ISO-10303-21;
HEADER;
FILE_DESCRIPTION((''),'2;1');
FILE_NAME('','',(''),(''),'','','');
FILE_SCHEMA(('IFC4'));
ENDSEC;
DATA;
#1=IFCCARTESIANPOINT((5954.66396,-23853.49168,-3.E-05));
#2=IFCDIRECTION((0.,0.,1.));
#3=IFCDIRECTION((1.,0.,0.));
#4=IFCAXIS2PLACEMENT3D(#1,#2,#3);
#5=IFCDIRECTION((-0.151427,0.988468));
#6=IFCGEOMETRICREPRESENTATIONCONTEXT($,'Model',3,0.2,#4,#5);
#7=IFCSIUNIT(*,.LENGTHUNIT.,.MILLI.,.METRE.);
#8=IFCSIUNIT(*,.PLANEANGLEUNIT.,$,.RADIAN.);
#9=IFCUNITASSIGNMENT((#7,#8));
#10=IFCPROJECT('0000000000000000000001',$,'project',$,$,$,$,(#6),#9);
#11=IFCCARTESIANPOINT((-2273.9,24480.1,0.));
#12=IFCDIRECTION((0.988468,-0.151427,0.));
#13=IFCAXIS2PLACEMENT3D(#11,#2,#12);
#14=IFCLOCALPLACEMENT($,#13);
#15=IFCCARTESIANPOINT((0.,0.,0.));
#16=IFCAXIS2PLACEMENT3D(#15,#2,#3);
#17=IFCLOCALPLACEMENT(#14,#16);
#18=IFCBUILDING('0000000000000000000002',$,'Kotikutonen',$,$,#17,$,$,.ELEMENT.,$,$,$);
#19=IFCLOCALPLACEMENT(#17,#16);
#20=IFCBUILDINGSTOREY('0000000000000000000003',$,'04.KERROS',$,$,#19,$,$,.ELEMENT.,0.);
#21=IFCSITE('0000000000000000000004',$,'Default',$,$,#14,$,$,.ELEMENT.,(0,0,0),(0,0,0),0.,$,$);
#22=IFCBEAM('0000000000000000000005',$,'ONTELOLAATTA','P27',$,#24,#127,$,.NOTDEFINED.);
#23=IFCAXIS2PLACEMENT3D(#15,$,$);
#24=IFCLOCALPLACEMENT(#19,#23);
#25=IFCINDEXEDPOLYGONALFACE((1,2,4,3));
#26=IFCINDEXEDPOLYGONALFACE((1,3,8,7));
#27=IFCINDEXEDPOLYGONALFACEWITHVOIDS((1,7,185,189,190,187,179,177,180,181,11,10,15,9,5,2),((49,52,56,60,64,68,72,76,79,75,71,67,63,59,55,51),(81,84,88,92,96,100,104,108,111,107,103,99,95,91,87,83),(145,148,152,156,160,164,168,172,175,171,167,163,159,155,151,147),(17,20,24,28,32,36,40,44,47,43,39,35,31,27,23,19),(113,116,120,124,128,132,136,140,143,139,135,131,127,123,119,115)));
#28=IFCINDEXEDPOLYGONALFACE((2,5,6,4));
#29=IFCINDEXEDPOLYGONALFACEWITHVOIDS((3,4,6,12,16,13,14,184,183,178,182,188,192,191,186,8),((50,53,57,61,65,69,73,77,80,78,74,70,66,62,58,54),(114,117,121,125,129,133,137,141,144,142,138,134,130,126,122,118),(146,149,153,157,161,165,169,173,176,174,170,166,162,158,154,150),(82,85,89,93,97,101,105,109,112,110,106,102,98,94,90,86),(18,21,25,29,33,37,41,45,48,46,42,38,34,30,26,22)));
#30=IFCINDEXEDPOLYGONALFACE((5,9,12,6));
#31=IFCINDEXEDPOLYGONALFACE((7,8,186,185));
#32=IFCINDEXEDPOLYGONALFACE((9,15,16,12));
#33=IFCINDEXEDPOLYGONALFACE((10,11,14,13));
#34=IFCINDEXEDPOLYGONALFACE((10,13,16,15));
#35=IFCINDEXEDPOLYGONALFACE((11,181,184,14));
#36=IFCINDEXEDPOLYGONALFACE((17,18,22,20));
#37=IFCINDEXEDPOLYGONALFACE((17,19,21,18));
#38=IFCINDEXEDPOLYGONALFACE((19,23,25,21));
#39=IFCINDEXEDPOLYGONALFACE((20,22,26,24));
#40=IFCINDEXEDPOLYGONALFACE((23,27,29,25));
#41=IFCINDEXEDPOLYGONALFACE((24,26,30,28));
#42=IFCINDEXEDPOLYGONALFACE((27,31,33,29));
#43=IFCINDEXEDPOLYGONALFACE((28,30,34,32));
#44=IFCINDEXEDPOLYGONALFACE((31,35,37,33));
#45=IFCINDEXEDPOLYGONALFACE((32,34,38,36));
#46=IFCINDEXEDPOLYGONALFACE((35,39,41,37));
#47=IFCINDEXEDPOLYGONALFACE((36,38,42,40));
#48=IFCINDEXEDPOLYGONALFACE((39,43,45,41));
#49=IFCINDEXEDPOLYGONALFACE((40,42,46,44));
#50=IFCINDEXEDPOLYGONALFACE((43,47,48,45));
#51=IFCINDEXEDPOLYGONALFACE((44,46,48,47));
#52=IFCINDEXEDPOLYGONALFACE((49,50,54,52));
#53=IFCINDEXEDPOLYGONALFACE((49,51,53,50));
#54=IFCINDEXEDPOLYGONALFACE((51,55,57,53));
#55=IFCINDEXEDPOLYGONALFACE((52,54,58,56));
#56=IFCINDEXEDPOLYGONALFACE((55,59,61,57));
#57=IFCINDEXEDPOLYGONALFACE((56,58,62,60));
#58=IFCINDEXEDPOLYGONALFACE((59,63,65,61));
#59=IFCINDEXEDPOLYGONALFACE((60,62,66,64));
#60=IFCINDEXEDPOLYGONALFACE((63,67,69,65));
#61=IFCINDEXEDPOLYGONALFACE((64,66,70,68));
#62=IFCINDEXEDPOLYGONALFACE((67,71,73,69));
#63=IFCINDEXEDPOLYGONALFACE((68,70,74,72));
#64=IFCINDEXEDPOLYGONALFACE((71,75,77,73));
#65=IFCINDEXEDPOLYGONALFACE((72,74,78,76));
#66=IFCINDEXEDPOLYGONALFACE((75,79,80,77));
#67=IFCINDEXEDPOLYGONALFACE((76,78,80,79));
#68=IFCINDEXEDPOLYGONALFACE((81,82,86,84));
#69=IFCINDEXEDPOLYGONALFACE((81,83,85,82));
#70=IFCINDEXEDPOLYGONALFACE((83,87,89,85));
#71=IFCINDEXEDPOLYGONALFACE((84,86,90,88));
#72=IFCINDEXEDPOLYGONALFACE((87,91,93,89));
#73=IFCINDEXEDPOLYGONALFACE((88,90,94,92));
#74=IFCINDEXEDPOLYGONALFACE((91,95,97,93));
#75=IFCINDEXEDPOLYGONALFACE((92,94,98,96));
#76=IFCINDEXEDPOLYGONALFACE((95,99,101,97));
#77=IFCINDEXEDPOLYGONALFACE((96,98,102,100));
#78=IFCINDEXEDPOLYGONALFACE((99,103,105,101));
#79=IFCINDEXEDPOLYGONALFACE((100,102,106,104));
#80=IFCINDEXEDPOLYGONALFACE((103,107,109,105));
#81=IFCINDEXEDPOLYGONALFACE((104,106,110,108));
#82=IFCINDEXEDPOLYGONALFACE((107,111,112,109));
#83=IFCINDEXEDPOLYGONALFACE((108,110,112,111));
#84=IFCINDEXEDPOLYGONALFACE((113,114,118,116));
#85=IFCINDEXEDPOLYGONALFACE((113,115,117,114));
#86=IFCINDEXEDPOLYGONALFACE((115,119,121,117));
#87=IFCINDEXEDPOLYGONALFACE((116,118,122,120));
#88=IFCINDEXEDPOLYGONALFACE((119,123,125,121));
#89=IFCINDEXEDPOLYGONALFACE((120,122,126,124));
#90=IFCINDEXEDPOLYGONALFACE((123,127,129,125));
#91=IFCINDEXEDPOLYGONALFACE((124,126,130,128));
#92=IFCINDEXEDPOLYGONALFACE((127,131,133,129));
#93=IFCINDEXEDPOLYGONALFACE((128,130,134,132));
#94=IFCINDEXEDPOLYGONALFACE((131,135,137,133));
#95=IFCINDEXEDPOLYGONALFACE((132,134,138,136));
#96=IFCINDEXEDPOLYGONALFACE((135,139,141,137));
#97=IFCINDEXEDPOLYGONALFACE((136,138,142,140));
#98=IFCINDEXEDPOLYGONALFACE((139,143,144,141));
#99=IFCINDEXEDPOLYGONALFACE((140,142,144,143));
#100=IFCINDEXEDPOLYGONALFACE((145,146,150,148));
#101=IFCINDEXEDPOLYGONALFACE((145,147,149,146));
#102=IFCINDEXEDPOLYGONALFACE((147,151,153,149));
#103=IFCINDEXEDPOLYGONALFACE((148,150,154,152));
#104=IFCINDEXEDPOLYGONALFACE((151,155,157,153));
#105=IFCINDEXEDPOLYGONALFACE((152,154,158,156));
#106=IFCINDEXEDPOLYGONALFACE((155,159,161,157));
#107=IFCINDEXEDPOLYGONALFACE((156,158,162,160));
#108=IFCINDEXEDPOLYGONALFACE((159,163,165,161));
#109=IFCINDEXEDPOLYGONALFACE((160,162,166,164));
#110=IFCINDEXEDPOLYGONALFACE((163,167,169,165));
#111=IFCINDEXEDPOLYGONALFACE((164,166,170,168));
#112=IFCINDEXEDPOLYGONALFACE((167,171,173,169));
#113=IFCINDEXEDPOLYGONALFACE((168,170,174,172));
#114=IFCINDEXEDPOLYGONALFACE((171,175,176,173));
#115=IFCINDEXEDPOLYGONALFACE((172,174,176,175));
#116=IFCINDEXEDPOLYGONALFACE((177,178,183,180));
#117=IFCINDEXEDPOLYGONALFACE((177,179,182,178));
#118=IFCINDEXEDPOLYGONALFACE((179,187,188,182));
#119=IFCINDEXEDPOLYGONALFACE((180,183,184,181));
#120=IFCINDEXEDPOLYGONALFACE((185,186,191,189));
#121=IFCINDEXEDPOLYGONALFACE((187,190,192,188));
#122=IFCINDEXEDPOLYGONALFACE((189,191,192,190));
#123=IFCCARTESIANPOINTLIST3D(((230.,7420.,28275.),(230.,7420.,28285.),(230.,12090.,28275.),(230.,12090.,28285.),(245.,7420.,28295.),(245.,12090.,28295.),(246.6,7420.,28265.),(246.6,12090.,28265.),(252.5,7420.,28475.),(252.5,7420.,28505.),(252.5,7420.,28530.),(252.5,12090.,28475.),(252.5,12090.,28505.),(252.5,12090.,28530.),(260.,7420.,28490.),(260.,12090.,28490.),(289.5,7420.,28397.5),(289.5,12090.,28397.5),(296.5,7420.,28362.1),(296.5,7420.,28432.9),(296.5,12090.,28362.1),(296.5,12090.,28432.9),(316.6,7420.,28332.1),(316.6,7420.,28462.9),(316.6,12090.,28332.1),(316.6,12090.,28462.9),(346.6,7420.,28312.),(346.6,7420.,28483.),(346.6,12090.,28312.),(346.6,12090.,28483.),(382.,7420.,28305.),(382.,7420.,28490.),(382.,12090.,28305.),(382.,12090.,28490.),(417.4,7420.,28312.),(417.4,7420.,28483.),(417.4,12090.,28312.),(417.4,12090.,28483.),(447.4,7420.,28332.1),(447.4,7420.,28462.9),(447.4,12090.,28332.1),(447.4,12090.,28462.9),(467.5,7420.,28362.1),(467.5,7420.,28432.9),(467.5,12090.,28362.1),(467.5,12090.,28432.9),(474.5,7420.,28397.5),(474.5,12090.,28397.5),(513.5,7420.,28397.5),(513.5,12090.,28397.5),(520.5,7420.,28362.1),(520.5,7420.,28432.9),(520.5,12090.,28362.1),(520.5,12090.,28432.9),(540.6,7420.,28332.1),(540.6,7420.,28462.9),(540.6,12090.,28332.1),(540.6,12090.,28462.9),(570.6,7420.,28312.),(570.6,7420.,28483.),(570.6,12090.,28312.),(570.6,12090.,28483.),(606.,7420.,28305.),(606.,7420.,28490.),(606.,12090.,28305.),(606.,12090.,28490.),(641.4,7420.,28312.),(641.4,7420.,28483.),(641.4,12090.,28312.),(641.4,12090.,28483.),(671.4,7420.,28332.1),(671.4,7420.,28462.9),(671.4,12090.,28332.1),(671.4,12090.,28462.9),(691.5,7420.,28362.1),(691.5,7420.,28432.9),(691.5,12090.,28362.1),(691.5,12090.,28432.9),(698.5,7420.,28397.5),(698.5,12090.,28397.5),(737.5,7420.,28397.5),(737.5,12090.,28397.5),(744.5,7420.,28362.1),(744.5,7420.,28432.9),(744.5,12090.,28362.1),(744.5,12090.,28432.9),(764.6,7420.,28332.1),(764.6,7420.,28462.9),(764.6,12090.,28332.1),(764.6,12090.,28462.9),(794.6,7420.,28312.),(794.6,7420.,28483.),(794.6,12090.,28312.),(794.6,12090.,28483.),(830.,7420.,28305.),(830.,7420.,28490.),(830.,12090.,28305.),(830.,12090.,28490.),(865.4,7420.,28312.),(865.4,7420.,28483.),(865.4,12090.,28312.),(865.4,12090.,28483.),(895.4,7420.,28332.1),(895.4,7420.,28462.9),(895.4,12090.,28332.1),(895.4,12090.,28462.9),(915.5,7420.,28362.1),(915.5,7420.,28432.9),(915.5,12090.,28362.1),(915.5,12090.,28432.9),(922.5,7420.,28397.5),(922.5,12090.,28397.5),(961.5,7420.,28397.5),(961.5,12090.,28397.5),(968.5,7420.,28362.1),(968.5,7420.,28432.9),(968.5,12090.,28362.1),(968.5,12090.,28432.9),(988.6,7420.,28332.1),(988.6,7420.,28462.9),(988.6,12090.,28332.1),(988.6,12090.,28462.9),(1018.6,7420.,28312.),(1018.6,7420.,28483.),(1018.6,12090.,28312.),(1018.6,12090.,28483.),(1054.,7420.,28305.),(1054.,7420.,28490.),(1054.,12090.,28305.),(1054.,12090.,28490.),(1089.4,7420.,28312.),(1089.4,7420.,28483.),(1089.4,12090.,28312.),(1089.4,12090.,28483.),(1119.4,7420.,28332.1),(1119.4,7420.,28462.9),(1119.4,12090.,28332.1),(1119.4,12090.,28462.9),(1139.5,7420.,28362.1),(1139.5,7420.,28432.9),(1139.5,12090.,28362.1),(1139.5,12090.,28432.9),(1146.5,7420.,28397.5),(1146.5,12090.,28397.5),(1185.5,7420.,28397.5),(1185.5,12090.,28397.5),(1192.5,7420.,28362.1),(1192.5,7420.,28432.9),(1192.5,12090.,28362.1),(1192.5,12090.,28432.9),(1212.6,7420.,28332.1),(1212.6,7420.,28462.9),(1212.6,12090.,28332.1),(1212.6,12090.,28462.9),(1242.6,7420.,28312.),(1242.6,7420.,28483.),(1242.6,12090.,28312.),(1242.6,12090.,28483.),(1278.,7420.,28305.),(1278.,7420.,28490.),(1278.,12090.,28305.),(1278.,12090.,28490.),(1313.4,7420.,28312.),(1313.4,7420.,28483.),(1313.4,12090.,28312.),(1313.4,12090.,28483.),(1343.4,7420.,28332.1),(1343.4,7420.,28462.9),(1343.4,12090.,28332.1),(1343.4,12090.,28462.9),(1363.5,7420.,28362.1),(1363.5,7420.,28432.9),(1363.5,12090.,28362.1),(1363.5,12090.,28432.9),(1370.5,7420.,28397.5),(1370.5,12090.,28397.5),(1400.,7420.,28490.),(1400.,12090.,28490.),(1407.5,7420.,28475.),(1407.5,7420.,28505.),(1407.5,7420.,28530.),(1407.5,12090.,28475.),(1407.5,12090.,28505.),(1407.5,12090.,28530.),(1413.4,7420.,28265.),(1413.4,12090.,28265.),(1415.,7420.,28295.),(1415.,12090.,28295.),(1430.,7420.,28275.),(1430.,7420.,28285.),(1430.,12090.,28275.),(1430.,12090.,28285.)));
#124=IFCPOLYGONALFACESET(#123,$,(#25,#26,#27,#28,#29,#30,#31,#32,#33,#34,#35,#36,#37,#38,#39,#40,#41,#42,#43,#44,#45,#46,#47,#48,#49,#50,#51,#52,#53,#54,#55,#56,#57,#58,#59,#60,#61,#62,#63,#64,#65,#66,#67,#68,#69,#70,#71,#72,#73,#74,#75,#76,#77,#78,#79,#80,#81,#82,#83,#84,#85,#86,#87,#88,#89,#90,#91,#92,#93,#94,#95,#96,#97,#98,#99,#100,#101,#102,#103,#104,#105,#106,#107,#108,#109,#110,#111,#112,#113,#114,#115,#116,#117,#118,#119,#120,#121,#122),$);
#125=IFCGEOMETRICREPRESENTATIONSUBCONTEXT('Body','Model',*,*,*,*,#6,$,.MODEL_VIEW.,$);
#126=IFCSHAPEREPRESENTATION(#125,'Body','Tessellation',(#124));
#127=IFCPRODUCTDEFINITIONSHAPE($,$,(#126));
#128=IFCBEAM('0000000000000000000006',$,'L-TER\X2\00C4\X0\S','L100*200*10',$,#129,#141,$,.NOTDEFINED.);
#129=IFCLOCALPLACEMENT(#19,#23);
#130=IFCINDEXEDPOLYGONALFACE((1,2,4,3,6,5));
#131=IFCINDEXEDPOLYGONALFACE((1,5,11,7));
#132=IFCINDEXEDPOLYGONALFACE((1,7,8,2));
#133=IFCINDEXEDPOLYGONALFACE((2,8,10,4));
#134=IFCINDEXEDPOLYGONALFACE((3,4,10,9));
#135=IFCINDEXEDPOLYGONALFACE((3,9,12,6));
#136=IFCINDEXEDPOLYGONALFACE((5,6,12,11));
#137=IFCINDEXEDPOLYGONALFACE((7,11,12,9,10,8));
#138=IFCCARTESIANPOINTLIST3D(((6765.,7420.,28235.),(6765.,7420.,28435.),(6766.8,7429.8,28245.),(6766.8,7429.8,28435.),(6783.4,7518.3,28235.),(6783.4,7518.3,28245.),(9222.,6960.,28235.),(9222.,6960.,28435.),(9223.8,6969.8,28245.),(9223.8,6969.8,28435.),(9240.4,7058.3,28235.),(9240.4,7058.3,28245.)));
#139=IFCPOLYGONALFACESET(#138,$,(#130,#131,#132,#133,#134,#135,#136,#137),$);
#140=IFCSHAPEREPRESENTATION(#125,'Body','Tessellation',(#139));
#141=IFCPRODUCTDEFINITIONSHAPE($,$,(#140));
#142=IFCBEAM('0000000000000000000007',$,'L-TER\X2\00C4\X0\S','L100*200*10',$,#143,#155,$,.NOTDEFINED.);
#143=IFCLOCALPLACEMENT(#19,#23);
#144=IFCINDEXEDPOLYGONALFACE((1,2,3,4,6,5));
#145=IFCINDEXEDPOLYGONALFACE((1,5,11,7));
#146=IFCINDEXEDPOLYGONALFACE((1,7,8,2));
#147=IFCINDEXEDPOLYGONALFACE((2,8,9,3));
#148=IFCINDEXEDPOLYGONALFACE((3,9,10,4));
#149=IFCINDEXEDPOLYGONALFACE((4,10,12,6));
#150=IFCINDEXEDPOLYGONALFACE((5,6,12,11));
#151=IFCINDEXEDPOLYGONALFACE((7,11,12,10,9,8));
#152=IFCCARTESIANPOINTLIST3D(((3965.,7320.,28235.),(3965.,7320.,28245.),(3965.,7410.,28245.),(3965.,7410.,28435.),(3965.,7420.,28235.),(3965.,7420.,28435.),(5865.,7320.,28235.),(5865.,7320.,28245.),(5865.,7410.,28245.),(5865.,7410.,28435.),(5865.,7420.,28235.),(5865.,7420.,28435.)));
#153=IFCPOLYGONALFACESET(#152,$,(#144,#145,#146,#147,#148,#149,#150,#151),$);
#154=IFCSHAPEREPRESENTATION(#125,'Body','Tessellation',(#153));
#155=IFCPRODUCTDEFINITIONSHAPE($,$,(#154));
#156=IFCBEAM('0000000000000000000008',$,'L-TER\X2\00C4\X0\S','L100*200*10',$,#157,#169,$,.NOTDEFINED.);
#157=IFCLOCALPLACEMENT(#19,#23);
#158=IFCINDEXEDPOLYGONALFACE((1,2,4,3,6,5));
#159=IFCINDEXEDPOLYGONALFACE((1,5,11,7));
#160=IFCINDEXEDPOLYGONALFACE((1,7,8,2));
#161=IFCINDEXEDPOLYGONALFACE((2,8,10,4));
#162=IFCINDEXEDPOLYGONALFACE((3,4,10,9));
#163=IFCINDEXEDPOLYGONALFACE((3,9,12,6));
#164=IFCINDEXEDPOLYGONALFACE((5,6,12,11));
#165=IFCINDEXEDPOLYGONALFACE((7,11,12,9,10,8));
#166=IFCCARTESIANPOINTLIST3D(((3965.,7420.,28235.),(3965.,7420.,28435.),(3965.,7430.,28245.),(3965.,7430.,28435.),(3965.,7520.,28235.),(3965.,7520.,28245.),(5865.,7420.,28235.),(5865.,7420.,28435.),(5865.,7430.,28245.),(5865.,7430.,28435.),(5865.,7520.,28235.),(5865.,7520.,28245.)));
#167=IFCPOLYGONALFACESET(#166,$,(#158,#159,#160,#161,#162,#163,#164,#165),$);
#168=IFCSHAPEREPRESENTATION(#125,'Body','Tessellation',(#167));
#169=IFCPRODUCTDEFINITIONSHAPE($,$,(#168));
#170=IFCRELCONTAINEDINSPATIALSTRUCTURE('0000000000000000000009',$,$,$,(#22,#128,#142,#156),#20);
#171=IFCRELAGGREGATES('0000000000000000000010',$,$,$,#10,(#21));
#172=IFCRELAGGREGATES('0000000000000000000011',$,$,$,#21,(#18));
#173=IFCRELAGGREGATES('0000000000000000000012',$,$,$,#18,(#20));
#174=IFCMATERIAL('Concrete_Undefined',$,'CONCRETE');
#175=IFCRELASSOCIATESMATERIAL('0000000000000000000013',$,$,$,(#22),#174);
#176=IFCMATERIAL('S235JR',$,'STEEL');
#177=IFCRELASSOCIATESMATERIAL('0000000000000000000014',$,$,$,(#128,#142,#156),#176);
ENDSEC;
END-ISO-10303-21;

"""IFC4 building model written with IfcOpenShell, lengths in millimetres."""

from ifc_helpers import new_model, si_unit, direction, frame, origin_with_axes, place, context, subcontext, project, spatial, line, indexed_curve, outline, extrude, material, element, save


model = new_model("IFC4")

# Units and contexts
model_context = context("Model", 3, precision=0.2, world=frame((5954.66396, -23853.49168, -3e-05), z_axis=(0.0, 0.0, 1.0), x_axis=(1.0, 0.0, 0.0)), true_north=direction((-0.151427, 0.988468)))
body_context = subcontext(model_context, "Body", "Model", "MODEL_VIEW")
ifc_project = project(units=[si_unit("LENGTHUNIT", "METRE", prefix="MILLI"), si_unit("PLANEANGLEUNIT", "RADIAN")], contexts=[model_context])

# Site, building, storey
site_placement = place(None, frame((-2273.9, 24480.1, 0.0), z_axis=(0.0, 0.0, 1.0), x_axis=(0.988468, -0.151427, 0.0)))
site = spatial("IfcSite", under=ifc_project, at=site_placement, Name="Default", CompositionType="ELEMENT", RefLatitude=(0, 0, 0), RefLongitude=(0, 0, 0), RefElevation=0.0)
building_placement = place(site_placement, origin_with_axes())
building = spatial("IfcBuilding", under=site, at=building_placement, Name="Kotikutonen", CompositionType="ELEMENT")
storey_placement = place(building_placement, origin_with_axes())
storey = spatial("IfcBuildingStorey", under=building, at=storey_placement, Name="04.KERROS", CompositionType="ELEMENT", Elevation=0.0)

# Beams
ifc_material_1 = material(Name="Concrete_Undefined", Category="CONCRETE")
beam_1_placement = place(storey_placement, frame((830.0, 12090.0, 28397.5), z_axis=(-1.0, 0.0, 0.0), x_axis=(0.0, -1.0, 0.0)))
element("IfcBeam", 1, at=beam_1_placement, inside=storey, material=ifc_material_1, Name="ONTELOLAATTA", Description="P27", PredefinedType="NOTDEFINED", context=body_context, shape_type="SolidModel", body=[
    extrude(outline(indexed_curve([(-600.0, -122.5), (-583.4, -132.5), (583.4, -132.5), (600.0, -122.5), (600.0, -112.5), (585.0, -102.5), (577.5, 77.5), (570.0, 92.5), (577.5, 107.5), (577.5, 132.5), (-577.5, 132.5), (-577.5, 107.5), (-570.0, 92.5), (-577.5, 77.5), (-585.0, -102.5), (-600.0, -112.5)], segments=[line(1, 2, 3, 4, 5, 6, 7, 8, 9, 10, 11, 12, 13, 14, 15, 16, 1)]), holes=[indexed_curve([(-448.0, -92.5), (-483.4, -85.5), (-513.4, -65.4), (-533.5, -35.4), (-540.5, 0.0), (-533.5, 35.4), (-513.4, 65.4), (-483.4, 85.5), (-448.0, 92.5), (-412.6, 85.5), (-382.6, 65.4), (-362.5, 35.4), (-355.5, 0.0), (-362.5, -35.4), (-382.6, -65.4), (-412.6, -85.5)], segments=[line(1, 2, 3, 4, 5, 6, 7, 8, 9, 10, 11, 12, 13, 14, 15, 16, 1)]), indexed_curve([(-224.0, -92.5), (-259.4, -85.5), (-289.4, -65.4), (-309.5, -35.4), (-316.5, 0.0), (-309.5, 35.4), (-289.4, 65.4), (-259.4, 85.5), (-224.0, 92.5), (-188.6, 85.5), (-158.6, 65.4), (-138.5, 35.4), (-131.5, 0.0), (-138.5, -35.4), (-158.6, -65.4), (-188.6, -85.5)], segments=[line(1, 2, 3, 4, 5, 6, 7, 8, 9, 10, 11, 12, 13, 14, 15, 16, 1)]), indexed_curve([(0.0, -92.5), (-35.4, -85.5), (-65.4, -65.4), (-85.5, -35.4), (-92.5, 0.0), (-85.5, 35.4), (-65.4, 65.4), (-35.4, 85.5), (0.0, 92.5), (35.4, 85.5), (65.4, 65.4), (85.5, 35.4), (92.5, 0.0), (85.5, -35.4), (65.4, -65.4), (35.4, -85.5)], segments=[line(1, 2, 3, 4, 5, 6, 7, 8, 9, 10, 11, 12, 13, 14, 15, 16, 1)]), indexed_curve([(224.0, -92.5), (188.6, -85.5), (158.6, -65.4), (138.5, -35.4), (131.5, 0.0), (138.5, 35.4), (158.6, 65.4), (188.6, 85.5), (224.0, 92.5), (259.4, 85.5), (289.4, 65.4), (309.5, 35.4), (316.5, 0.0), (309.5, -35.4), (289.4, -65.4), (259.4, -85.5)], segments=[line(1, 2, 3, 4, 5, 6, 7, 8, 9, 10, 11, 12, 13, 14, 15, 16, 1)]), indexed_curve([(448.0, -92.5), (412.6, -85.5), (382.6, -65.4), (362.5, -35.4), (355.5, 0.0), (362.5, 35.4), (382.6, 65.4), (412.6, 85.5), (448.0, 92.5), (483.4, 85.5), (513.4, 65.4), (533.5, 35.4), (540.5, 0.0), (533.5, -35.4), (513.4, -65.4), (483.4, -85.5)], segments=[line(1, 2, 3, 4, 5, 6, 7, 8, 9, 10, 11, 12, 13, 14, 15, 16, 1)])]), frame((0.0, 0.0, 0.0), z_axis=(-1.0, 0.0, 0.0), x_axis=(0.0, 0.0, 1.0)), (0.0, 0.0, -1.0), 4670.0),
])
ifc_material_2 = material(Name="S235JR", Category="STEEL")
beam_2_placement = place(storey_placement, frame((6774.2, 7469.1, 28335.0), z_axis=(0.0, 0.0, 1.0), x_axis=(0.982922, -0.184023, 0.0)))
element("IfcBeam", 2, at=beam_2_placement, inside=storey, material=ifc_material_2, Name="L-TERÄS", Description="L100*200*10", PredefinedType="NOTDEFINED", context=body_context, shape_type="SolidModel", body=[
    extrude(outline(indexed_curve([(-100.0, -50.0), (100.0, -50.0), (100.0, -40.0), (-90.0, -40.0), (-90.0, 50.0), (-100.0, 50.0)], segments=[line(1, 2, 3, 4, 5, 6, 1)])), frame((0.0, 0.0, 0.0), z_axis=(-1.0, 0.0, 0.0), x_axis=(0.0, 0.0, 1.0)), (0.0, 0.0, -1.0), 2499.7),
])
for number, where, z_axis, x_axis, name in (
    (3, (5865.0, 7370.0, 28335.0), (0.0, 0.0, 1.0), (-1.0, 0.0, 0.0), "L-TERÄS"),
    (4, (3965.0, 7470.0, 28335.0), (0.0, 0.0, 1.0), (1.0, 0.0, 0.0), "L-TERÄS"),
):
    element("IfcBeam", number, at=place(storey_placement, frame(where, z_axis=z_axis, x_axis=x_axis)), inside=storey, material=ifc_material_2, Name=name, Description="L100*200*10", PredefinedType="NOTDEFINED", context=body_context, shape_type="SolidModel", body=[
        extrude(outline(indexed_curve([(-100.0, -50.0), (100.0, -50.0), (100.0, -40.0), (-90.0, -40.0), (-90.0, 50.0), (-100.0, 50.0)], segments=[line(1, 2, 3, 4, 5, 6, 1)])), frame((0.0, 0.0, 0.0), z_axis=(-1.0, 0.0, 0.0), x_axis=(0.0, 0.0, 1.0)), (0.0, 0.0, -1.0), 1900.0),
    ])

save(model, "model.ifc")
